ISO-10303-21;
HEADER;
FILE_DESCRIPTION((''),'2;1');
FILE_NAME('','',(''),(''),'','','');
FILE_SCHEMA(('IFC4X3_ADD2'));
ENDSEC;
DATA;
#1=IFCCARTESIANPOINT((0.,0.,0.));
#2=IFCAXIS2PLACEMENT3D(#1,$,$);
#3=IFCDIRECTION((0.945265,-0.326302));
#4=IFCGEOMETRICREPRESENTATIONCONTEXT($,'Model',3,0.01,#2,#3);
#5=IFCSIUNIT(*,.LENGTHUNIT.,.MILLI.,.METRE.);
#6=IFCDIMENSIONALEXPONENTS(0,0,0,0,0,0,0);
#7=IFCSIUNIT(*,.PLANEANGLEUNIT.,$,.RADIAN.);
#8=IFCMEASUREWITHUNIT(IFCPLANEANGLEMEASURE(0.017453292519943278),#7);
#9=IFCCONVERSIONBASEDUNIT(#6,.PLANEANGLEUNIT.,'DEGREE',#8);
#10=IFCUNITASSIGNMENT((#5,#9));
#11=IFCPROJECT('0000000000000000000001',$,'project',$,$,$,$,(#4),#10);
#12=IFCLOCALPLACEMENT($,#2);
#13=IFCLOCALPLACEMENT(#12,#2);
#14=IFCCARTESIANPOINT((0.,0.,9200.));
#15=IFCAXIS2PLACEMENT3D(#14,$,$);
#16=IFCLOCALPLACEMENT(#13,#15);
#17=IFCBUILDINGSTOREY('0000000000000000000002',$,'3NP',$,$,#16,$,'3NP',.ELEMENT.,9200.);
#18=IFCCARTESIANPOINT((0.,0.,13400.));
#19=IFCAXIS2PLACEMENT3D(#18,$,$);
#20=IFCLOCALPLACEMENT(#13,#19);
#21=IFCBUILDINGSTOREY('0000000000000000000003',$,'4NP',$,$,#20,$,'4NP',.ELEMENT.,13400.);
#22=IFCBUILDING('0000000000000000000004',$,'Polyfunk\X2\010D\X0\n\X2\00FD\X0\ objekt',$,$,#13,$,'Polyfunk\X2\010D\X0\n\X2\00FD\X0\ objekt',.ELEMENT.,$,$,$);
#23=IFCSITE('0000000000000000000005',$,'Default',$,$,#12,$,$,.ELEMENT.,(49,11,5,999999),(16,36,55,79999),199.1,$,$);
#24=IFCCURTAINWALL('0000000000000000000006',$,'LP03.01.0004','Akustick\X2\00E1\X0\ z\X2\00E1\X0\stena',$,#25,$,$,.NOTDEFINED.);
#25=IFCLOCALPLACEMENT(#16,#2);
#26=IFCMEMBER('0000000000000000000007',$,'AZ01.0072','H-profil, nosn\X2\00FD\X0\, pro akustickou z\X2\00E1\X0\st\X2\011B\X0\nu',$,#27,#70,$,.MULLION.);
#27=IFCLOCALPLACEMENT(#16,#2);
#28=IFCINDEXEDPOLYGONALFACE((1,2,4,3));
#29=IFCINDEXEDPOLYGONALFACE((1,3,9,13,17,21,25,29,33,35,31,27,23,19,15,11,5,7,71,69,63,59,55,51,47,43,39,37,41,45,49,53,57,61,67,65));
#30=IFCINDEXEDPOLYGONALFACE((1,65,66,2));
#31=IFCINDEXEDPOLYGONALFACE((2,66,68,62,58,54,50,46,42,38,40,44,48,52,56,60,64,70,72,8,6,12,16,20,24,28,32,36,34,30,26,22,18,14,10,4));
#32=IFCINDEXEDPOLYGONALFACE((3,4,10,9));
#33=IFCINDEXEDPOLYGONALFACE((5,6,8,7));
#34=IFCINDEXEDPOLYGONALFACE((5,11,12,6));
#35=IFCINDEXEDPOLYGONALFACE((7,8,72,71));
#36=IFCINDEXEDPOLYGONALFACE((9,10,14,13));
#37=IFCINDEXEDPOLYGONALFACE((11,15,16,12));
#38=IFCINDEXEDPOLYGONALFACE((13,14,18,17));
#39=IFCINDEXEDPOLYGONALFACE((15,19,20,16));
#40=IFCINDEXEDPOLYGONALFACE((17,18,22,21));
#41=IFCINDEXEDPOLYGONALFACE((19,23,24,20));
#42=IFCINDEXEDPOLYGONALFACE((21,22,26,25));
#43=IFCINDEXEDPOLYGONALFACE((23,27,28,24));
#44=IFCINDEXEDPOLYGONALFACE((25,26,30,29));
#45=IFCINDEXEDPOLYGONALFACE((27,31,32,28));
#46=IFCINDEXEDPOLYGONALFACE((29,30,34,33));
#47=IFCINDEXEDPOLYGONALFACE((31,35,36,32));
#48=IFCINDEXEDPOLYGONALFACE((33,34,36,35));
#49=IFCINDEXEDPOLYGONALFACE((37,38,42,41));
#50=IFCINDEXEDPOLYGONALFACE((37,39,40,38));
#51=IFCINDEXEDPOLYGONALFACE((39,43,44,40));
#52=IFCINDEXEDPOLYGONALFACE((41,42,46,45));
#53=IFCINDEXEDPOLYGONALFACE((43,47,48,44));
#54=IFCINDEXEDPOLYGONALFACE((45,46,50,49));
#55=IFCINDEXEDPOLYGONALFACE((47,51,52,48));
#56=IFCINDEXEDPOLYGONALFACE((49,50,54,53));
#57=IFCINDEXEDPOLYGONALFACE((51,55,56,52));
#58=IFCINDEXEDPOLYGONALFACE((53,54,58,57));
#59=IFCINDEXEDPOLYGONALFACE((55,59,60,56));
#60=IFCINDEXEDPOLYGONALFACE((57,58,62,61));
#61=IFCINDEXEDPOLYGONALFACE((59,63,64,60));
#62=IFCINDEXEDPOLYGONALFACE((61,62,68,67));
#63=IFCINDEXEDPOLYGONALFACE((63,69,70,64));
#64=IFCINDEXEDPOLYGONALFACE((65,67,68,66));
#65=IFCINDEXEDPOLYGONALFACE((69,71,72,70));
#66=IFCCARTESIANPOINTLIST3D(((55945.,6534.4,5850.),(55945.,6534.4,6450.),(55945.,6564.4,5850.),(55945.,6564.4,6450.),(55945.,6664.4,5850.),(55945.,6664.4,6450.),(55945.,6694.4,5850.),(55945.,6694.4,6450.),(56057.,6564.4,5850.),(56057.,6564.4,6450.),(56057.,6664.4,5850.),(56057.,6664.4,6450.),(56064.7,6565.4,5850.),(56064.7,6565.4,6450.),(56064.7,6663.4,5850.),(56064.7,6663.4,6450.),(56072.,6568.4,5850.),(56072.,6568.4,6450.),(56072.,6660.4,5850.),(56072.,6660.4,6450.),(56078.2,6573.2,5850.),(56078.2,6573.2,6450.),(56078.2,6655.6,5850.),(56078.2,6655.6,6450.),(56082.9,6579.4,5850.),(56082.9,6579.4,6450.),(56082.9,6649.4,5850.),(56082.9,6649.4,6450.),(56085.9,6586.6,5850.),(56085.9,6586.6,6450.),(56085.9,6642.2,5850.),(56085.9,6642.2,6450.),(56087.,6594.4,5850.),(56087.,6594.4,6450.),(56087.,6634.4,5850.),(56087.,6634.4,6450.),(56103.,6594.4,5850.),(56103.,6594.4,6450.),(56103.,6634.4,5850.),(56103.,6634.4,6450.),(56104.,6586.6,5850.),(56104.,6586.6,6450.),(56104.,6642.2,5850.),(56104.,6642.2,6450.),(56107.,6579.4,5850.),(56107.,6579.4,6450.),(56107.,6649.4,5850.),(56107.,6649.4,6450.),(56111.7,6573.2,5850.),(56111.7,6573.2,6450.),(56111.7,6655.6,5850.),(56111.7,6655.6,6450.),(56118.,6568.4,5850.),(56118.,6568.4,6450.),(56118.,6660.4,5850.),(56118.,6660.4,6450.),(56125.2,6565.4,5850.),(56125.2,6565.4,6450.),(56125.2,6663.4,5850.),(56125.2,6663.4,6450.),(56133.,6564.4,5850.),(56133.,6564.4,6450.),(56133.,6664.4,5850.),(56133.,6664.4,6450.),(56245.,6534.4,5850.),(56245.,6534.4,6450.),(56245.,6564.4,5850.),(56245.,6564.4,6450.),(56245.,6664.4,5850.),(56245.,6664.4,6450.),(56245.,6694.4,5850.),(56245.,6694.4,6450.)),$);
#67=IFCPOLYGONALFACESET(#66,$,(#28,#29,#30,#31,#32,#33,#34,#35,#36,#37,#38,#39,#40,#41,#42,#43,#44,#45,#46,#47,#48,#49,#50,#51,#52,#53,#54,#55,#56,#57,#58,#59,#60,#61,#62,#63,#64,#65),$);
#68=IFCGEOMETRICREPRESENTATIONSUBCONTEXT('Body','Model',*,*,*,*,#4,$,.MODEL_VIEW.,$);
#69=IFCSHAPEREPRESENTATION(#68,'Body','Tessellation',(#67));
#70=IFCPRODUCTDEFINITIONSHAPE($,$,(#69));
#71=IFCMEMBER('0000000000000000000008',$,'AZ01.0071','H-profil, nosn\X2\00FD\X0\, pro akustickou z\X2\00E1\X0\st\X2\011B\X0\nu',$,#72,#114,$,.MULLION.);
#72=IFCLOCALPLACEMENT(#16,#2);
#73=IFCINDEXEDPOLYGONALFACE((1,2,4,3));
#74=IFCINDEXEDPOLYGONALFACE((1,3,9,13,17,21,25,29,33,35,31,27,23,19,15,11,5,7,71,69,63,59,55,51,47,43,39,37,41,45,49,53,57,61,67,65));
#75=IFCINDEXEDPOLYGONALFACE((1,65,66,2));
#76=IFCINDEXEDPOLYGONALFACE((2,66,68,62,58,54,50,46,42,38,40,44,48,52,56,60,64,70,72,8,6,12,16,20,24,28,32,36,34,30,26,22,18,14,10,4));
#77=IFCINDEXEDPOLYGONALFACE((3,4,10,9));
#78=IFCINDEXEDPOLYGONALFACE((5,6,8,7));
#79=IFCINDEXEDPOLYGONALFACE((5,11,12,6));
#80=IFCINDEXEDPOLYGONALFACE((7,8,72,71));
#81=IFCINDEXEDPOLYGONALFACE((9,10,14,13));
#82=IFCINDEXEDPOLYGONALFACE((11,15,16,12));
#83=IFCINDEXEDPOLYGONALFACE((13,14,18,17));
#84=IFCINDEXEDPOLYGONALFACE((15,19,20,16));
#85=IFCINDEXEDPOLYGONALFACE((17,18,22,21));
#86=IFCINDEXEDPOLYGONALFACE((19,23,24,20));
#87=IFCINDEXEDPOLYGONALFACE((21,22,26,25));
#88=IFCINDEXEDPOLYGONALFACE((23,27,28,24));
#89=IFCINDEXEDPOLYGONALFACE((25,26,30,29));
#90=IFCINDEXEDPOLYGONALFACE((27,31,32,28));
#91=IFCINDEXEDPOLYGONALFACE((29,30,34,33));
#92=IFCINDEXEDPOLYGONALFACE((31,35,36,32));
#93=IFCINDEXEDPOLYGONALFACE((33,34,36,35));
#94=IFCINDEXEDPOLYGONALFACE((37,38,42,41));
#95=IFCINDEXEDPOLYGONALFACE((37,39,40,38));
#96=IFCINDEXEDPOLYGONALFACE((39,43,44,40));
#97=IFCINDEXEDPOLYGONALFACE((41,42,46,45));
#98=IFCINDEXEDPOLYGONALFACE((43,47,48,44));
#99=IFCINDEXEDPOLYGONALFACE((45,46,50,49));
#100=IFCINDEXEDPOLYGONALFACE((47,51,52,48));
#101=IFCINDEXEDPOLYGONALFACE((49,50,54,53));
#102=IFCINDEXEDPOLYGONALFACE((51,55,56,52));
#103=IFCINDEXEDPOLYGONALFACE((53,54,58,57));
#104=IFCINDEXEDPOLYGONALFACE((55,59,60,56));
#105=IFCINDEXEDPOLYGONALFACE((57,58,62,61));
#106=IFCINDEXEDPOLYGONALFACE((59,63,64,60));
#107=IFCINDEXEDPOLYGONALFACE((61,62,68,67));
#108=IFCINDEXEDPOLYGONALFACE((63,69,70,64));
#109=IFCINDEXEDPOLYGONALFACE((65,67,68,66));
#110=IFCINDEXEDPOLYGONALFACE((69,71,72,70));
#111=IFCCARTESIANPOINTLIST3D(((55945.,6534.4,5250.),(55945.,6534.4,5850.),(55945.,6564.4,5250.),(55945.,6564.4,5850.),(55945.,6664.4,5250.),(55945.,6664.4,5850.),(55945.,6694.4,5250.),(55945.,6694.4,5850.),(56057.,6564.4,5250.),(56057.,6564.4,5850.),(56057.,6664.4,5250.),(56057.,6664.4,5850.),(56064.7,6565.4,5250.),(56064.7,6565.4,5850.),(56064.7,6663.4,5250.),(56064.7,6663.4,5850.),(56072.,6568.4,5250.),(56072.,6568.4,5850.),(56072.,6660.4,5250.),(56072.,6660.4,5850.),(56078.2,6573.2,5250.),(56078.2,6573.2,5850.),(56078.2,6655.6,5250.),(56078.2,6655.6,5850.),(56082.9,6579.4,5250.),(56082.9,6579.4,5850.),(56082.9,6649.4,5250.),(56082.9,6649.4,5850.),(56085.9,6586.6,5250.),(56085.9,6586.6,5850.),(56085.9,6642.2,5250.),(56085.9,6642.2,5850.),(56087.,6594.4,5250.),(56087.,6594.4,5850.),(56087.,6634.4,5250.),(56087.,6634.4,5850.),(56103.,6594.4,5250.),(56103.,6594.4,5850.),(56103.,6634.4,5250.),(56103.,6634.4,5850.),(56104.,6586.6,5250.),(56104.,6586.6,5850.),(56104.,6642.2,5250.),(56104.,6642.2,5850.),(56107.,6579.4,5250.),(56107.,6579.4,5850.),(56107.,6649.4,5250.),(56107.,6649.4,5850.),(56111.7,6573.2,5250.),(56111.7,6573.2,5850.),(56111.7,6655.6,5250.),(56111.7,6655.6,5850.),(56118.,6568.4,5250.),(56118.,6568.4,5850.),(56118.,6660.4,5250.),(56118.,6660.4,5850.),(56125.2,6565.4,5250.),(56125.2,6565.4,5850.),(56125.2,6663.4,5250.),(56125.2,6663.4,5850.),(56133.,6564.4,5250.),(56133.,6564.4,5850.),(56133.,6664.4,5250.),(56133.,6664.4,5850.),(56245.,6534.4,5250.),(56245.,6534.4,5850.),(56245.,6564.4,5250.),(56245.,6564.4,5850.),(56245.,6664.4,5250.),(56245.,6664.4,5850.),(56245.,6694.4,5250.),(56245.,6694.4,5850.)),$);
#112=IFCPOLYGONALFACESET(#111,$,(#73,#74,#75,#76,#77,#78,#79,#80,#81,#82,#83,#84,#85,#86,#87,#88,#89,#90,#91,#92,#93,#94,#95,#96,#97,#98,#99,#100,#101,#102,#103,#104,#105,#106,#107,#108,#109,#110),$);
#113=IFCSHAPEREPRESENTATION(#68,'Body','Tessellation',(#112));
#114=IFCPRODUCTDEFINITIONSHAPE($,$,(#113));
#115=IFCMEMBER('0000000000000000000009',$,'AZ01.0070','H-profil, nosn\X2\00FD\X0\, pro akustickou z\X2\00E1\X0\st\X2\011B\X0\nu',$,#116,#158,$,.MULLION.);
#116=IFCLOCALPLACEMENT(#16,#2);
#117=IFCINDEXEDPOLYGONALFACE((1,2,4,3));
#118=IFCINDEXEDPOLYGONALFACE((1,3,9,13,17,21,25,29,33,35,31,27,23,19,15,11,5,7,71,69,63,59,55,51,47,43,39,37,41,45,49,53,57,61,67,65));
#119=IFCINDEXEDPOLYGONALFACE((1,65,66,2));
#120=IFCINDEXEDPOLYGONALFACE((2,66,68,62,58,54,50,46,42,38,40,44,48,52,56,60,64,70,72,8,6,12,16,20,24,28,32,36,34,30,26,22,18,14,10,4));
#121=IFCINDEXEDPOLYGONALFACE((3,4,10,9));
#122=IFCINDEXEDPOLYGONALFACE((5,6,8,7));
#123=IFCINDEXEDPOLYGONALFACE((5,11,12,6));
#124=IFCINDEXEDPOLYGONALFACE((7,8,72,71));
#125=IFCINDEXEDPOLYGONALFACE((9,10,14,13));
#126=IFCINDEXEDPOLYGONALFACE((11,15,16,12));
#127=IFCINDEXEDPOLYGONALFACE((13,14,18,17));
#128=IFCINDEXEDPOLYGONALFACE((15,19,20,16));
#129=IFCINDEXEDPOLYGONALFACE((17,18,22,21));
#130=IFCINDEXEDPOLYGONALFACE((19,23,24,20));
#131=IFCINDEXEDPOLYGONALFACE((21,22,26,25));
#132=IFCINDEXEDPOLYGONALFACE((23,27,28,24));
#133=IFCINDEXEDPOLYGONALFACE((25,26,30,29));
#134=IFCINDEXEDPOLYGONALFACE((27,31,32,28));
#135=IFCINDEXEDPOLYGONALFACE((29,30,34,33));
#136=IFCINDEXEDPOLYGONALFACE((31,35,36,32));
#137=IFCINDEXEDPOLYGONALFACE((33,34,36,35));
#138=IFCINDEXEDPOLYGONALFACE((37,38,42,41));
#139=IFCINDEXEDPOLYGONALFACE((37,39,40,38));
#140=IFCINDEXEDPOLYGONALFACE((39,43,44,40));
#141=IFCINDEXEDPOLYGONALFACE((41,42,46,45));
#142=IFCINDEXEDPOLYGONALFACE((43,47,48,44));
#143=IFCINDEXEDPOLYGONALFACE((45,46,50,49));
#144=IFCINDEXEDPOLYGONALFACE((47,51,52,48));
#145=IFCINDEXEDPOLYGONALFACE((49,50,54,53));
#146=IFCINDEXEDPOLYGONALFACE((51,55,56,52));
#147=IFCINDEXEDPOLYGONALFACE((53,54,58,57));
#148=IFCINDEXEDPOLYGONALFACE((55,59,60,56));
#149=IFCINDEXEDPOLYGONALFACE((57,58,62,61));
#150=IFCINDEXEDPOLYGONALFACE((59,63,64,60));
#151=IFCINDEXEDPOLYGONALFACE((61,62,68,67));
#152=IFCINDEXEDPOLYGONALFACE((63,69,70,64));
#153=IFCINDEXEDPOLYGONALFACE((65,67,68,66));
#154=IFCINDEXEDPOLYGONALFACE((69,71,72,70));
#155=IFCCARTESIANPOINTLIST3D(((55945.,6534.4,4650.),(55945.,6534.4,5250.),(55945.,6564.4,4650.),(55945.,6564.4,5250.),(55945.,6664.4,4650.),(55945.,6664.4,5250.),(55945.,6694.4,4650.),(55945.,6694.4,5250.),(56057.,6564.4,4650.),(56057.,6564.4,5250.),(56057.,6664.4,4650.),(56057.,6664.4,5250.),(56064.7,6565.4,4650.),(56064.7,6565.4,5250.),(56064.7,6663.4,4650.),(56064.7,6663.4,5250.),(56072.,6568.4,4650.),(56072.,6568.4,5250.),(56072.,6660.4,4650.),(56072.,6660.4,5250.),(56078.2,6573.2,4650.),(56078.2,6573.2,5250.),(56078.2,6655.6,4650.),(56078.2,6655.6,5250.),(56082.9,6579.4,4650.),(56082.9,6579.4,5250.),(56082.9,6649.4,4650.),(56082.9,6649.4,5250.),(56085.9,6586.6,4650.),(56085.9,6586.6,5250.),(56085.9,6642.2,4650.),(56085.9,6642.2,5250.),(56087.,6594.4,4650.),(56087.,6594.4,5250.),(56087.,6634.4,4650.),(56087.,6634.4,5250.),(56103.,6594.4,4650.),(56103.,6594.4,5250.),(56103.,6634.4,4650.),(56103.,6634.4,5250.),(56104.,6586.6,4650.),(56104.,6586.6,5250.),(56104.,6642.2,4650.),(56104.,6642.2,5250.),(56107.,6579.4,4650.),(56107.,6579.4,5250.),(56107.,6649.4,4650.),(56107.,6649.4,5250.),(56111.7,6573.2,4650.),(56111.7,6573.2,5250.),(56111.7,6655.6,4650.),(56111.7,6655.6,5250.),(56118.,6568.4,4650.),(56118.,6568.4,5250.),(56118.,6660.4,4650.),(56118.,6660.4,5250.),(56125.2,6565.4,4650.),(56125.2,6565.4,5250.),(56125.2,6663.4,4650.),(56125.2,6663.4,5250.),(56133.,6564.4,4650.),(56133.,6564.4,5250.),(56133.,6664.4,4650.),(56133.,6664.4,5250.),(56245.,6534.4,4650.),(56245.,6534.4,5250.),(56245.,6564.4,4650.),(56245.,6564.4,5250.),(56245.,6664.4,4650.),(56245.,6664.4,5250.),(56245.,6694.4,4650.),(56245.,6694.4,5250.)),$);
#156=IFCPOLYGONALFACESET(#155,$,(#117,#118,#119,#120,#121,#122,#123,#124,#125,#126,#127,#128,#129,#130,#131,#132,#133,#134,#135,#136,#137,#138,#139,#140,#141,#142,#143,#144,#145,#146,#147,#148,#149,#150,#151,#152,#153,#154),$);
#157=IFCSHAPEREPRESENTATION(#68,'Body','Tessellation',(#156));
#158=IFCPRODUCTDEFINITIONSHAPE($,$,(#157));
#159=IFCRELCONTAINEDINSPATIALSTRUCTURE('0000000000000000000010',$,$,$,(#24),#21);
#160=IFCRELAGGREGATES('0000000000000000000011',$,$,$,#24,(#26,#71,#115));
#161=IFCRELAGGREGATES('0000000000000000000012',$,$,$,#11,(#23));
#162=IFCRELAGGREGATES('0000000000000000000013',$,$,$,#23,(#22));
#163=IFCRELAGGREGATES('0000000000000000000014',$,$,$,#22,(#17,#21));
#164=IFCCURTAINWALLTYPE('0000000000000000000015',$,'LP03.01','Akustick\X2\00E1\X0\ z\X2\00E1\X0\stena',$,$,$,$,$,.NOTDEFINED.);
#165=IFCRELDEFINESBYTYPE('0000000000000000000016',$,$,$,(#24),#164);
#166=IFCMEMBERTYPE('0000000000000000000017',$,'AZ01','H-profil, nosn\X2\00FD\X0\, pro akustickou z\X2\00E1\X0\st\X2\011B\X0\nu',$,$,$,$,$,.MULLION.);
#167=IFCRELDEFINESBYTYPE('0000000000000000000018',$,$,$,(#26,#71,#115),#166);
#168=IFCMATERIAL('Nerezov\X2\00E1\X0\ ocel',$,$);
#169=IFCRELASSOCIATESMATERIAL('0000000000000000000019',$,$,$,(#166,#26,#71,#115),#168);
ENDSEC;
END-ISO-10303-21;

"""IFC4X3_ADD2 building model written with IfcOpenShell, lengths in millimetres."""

from ifc_helpers import new_model, entity, si_unit, converted_unit, direction, frame, frame_2d, origin, place, context, subcontext, project, spatial, polyline, circle_curve, parameter, trimmed, segment, composite_curve, outline, extrude, source, transform, mapped, material, material_profile, profile_set, profile_usage, type_object, element, aggregate, save


model = new_model("IFC4X3_ADD2")

# Units and contexts
model_context = context("Model", 3, precision=0.01, world=origin(), true_north=direction((0.945265, -0.326302)))
body_context = subcontext(model_context, "Body", "Model", "MODEL_VIEW")
ifc_project = project(units=[si_unit("LENGTHUNIT", "METRE", prefix="MILLI"), converted_unit("PLANEANGLEUNIT", "DEGREE", entity("IfcPlaneAngleMeasure", 0.017453292519943278), si_unit("PLANEANGLEUNIT", "RADIAN"), dimensions=[0, 0, 0, 0, 0, 0, 0])], contexts=[model_context])

# Site, building, storey
site_placement = place(None, origin())
site = spatial("IfcSite", under=ifc_project, at=site_placement, Name="Default", CompositionType="ELEMENT", RefLatitude=(49, 11, 5, 999999), RefLongitude=(16, 36, 55, 79999), RefElevation=199.1)
building_placement = place(site_placement, origin())
building = spatial("IfcBuilding", under=site, at=building_placement, Name="Polyfunkčný objekt", LongName="Polyfunkčný objekt", CompositionType="ELEMENT")
storey_1_placement = place(building_placement, frame((0.0, 0.0, 9200.0)))
storey_1 = spatial("IfcBuildingStorey", under=building, at=storey_1_placement, Name="3NP", LongName="3NP", CompositionType="ELEMENT", Elevation=9200.0)

# Shared definitions
storey_2_placement = place(building_placement, frame((0.0, 0.0, 13400.0)))
storey_2 = spatial("IfcBuildingStorey", under=building, at=storey_2_placement, Name="4NP", LongName="4NP", CompositionType="ELEMENT", Elevation=13400.0)

# Curtain wall, members
curtain_wall_type_1 = type_object("IfcCurtainWallType", Name="LP03.01", Description="Akustická zástena", PredefinedType="NOTDEFINED")
curtain_wall_1_placement = place(storey_2_placement, frame((0.0, 0.0, -13400.0)))
curtain_wall_1 = element("IfcCurtainWall", 1, at=curtain_wall_1_placement, inside=storey_2, type_object=curtain_wall_type_1, Name="LP03.01.0004", Description="Akustická zástena", PredefinedType="NOTDEFINED")
ifc_material_1 = material(Name="Nerezová ocel")
ifc_material_profile_1 = material_profile(ifc_material_1, outline(composite_curve([segment(polyline([(50.0, -150.0), (80.0, -150.0)]), True, "CONTINUOUS"), segment(polyline([(80.0, -150.0), (80.0, 150.0)]), True, "CONTINUOUS"), segment(polyline([(80.0, 150.0), (50.0, 150.0)]), True, "CONTINUOUS"), segment(polyline([(50.0, 150.0), (50.0, 38.0)]), True, "CONTINUOUS"), segment(trimmed(circle_curve(frame_2d((20.0, 38.0), x_axis=(0.0, 1.0)), 30.0), [parameter(180.0)], [parameter(270.0)], True, "PARAMETER"), False, "CONTINUOUS"), segment(polyline([(20.0, 8.0), (-20.0, 8.0)]), True, "CONTINUOUS"), segment(trimmed(circle_curve(frame_2d((-20.0, 38.0), x_axis=(0.0, 1.0)), 30.0), [parameter(90.0)], [parameter(180.0)], True, "PARAMETER"), False, "CONTINUOUS"), segment(polyline([(-50.0, 38.0), (-50.0, 150.0)]), True, "CONTINUOUS"), segment(polyline([(-50.0, 150.0), (-80.0, 150.0)]), True, "CONTINUOUS"), segment(polyline([(-80.0, 150.0), (-80.0, -150.0)]), True, "CONTINUOUS"), segment(polyline([(-80.0, -150.0), (-50.0, -150.0)]), True, "CONTINUOUS"), segment(polyline([(-50.0, -150.0), (-50.0, -38.0)]), True, "CONTINUOUS"), segment(trimmed(circle_curve(frame_2d((-20.0, -38.0), x_axis=(0.0, 1.0)), 30.0), [parameter(0.0)], [parameter(90.0)], True, "PARAMETER"), False, "CONTINUOUS"), segment(polyline([(-20.0, -8.0), (20.0, -8.0)]), True, "CONTINUOUS"), segment(trimmed(circle_curve(frame_2d((20.0, -38.0), x_axis=(0.0, 1.0)), 30.0), [parameter(270.0)], [parameter(0.0)], True, "PARAMETER"), False, "CONTINUOUS"), segment(polyline([(50.0, -38.0), (50.0, -150.0)]), True, "CONTINUOUS")], self_intersect=False)), Name="Profil zástena")
ifc_profile_set_1 = profile_set([ifc_material_profile_1], Name="Profil zástena")
ifc_profile_usage_1 = profile_usage(ifc_profile_set_1)
member_type_1 = type_object("IfcMemberType", Name="AZ01", Description="H-profil, nosný, pro akustickou zástěnu", PredefinedType="MULLION", material=ifc_profile_set_1)
shared_shape_1 = source(origin(), body_context, "Body", "SweptSolid", [
    extrude(outline(composite_curve([segment(polyline([(50.0, -150.0), (80.0, -150.0)]), True, "CONTINUOUS"), segment(polyline([(80.0, -150.0), (80.0, 150.0)]), True, "CONTINUOUS"), segment(polyline([(80.0, 150.0), (50.0, 150.0)]), True, "CONTINUOUS"), segment(polyline([(50.0, 150.0), (50.0, 38.0)]), True, "CONTINUOUS"), segment(trimmed(circle_curve(frame_2d((20.0, 38.0), x_axis=(0.0, 1.0)), 30.0), [parameter(180.0)], [parameter(270.0)], True, "PARAMETER"), False, "CONTINUOUS"), segment(polyline([(20.0, 8.0), (-20.0, 8.0)]), True, "CONTINUOUS"), segment(trimmed(circle_curve(frame_2d((-20.0, 38.0), x_axis=(0.0, 1.0)), 30.0), [parameter(90.0)], [parameter(180.0)], True, "PARAMETER"), False, "CONTINUOUS"), segment(polyline([(-50.0, 38.0), (-50.0, 150.0)]), True, "CONTINUOUS"), segment(polyline([(-50.0, 150.0), (-80.0, 150.0)]), True, "CONTINUOUS"), segment(polyline([(-80.0, 150.0), (-80.0, -150.0)]), True, "CONTINUOUS"), segment(polyline([(-80.0, -150.0), (-50.0, -150.0)]), True, "CONTINUOUS"), segment(polyline([(-50.0, -150.0), (-50.0, -38.0)]), True, "CONTINUOUS"), segment(trimmed(circle_curve(frame_2d((-20.0, -38.0), x_axis=(0.0, 1.0)), 30.0), [parameter(0.0)], [parameter(90.0)], True, "PARAMETER"), False, "CONTINUOUS"), segment(polyline([(-20.0, -8.0), (20.0, -8.0)]), True, "CONTINUOUS"), segment(trimmed(circle_curve(frame_2d((20.0, -38.0), x_axis=(0.0, 1.0)), 30.0), [parameter(270.0)], [parameter(0.0)], True, "PARAMETER"), False, "CONTINUOUS"), segment(polyline([(50.0, -38.0), (50.0, -150.0)]), True, "CONTINUOUS")], self_intersect=False)), frame((-150.0, 0.0, -600.0), z_axis=(0.0, 0.0, 1.0), x_axis=(0.0, -1.0, 0.0)), (0.0, 0.0, 1.0), 600.0),
])
member_1_placement = place(curtain_wall_1_placement, frame((56245.0, 6614.4, 15050.0), z_axis=(0.0, 0.0, -1.0), x_axis=(1.0, 0.0, 0.0)))
member_1 = element("IfcMember", 2, at=member_1_placement, type_object=member_type_1, material=ifc_profile_usage_1, Name="AZ01.0072", Description="H-profil, nosný, pro akustickou zástěnu", PredefinedType="MULLION", context=body_context, shape_type="MappedRepresentation", body=[
    mapped(shared_shape_1, transform((0.0, 0.0, 0.0), scale=1.0)),
])
member_2_placement = place(curtain_wall_1_placement, frame((56245.0, 6614.4, 14450.0), z_axis=(0.0, 0.0, -1.0), x_axis=(1.0, 0.0, 0.0)))
member_2 = element("IfcMember", 3, at=member_2_placement, type_object=member_type_1, material=ifc_profile_usage_1, Name="AZ01.0071", Description="H-profil, nosný, pro akustickou zástěnu", PredefinedType="MULLION", context=body_context, shape_type="MappedRepresentation", body=[
    mapped(shared_shape_1, transform((0.0, 0.0, 0.0), scale=1.0)),
])
member_3_placement = place(curtain_wall_1_placement, frame((56245.0, 6614.4, 13850.0), z_axis=(0.0, 0.0, -1.0), x_axis=(1.0, 0.0, 0.0)))
member_3 = element("IfcMember", 4, at=member_3_placement, type_object=member_type_1, material=ifc_profile_usage_1, Name="AZ01.0070", Description="H-profil, nosný, pro akustickou zástěnu", PredefinedType="MULLION", context=body_context, shape_type="MappedRepresentation", body=[
    mapped(shared_shape_1, transform((0.0, 0.0, 0.0), scale=1.0)),
])
aggregate(curtain_wall_1, [member_1, member_2, member_3])

save(model, "model.ifc")
